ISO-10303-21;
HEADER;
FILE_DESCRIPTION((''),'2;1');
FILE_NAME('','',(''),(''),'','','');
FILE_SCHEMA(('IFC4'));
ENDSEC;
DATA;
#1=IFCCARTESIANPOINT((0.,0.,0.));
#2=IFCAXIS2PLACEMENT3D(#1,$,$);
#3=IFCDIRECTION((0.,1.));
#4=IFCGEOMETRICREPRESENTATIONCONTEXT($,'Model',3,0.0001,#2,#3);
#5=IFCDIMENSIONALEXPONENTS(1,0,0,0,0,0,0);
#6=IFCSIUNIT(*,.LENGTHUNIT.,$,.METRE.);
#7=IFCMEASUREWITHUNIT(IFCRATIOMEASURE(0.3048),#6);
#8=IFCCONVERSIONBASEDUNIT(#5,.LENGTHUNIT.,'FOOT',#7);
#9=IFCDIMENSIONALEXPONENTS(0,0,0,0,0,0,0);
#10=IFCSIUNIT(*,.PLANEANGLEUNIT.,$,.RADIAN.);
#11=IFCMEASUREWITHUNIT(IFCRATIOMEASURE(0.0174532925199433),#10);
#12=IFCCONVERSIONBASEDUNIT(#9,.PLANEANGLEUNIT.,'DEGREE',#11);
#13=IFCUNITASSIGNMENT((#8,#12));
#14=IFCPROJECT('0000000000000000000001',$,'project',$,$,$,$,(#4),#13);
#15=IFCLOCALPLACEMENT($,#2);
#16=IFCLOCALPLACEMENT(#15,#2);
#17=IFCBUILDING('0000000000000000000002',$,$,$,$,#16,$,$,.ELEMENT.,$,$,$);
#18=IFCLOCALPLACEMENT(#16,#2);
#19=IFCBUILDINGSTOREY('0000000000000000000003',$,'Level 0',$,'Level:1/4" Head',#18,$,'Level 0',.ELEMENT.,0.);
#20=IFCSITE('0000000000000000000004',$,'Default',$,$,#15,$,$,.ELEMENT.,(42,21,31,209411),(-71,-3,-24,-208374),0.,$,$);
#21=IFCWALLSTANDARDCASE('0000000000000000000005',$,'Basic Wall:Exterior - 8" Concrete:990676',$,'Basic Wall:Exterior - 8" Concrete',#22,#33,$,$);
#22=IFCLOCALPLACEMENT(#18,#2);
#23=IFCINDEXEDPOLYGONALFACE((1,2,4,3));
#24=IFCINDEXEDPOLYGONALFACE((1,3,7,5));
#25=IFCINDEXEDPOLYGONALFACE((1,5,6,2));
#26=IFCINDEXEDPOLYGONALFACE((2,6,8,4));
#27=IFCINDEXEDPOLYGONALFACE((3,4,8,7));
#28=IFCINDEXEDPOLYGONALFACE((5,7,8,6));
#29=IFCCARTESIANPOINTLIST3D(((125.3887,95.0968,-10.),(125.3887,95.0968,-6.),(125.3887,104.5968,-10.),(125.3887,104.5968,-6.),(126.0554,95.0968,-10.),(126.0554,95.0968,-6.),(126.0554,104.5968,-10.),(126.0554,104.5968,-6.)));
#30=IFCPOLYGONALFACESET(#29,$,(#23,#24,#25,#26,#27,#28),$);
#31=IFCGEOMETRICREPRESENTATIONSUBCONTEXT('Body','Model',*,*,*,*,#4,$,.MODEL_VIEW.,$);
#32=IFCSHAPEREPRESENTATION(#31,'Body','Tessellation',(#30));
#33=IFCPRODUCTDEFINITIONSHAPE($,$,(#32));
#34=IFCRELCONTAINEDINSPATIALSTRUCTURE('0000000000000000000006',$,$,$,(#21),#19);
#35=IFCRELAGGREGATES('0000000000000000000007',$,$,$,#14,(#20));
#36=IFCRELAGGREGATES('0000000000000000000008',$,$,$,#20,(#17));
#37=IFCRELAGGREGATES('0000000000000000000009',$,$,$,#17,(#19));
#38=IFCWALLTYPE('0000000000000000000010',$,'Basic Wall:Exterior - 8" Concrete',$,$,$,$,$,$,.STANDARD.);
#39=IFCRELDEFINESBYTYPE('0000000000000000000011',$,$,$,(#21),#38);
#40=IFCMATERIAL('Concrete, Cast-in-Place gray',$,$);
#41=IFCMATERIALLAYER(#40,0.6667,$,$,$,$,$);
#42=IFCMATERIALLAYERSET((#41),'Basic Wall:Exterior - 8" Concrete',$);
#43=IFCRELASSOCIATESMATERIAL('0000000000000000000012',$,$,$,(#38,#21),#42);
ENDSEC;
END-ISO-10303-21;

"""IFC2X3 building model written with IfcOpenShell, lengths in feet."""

from ifc_helpers import new_model, entity, si_unit, converted_unit, direction, frame, frame_2d, origin, place, context, subcontext, project, spatial, rectangle, extrude, material, layer, layer_set, layer_usage, type_object, element, save


model = new_model("IFC2X3")

# Units and contexts
model_context = context("Model", 3, precision=0.0001, world=origin(), true_north=direction((0.0, 1.0)))
body_context = subcontext(model_context, "Body", "Model", "MODEL_VIEW")
ifc_project = project(units=[converted_unit("LENGTHUNIT", "FOOT", entity("IfcRatioMeasure", 0.3048), si_unit("LENGTHUNIT", "METRE"), dimensions=[1, 0, 0, 0, 0, 0, 0]), converted_unit("PLANEANGLEUNIT", "DEGREE", entity("IfcRatioMeasure", 0.0174532925199433), si_unit("PLANEANGLEUNIT", "RADIAN"), dimensions=[0, 0, 0, 0, 0, 0, 0])], contexts=[model_context])

# Site, building, storey
site_placement = place(None, origin())
site = spatial("IfcSite", under=ifc_project, at=site_placement, Name="Default", CompositionType="ELEMENT", RefLatitude=(42, 21, 31, 209411), RefLongitude=(-71, -3, -24, -208374), RefElevation=0.0)
building_placement = place(site_placement, origin())
building = spatial("IfcBuilding", under=site, at=building_placement, CompositionType="ELEMENT")
storey_placement = place(building_placement, origin())
storey = spatial("IfcBuildingStorey", under=building, at=storey_placement, Name="Level 0", ObjectType="Level:1/4\" Head", LongName="Level 0", CompositionType="ELEMENT", Elevation=0.0)

# Wall
ifc_material_1 = material(Name="Concrete, Cast-in-Place gray")
ifc_layer = layer(ifc_material_1, 0.6667)
ifc_layer_set = layer_set([ifc_layer], Name="Basic Wall:Exterior - 8\" Concrete")
wall_type = type_object("IfcWallType", Name="Basic Wall:Exterior - 8\" Concrete", PredefinedType="STANDARD", material=ifc_layer_set)
ifc_layer_usage_1 = layer_usage(ifc_layer_set, "AXIS2", "NEGATIVE", 0.3333)
wall_1_placement = place(storey_placement, frame((125.722, 95.0968, -10.0), z_axis=(0.0, 0.0, 1.0), x_axis=(0.0, 1.0, 0.0)))
element("IfcWallStandardCase", 1, at=wall_1_placement, inside=storey, type_object=wall_type, material=ifc_layer_usage_1, Name="Basic Wall:Exterior - 8\" Concrete:990676", ObjectType="Basic Wall:Exterior - 8\" Concrete", context=body_context, shape_type="SweptSolid", body=[
    extrude(rectangle(XDim=9.5, YDim=0.6667, at=frame_2d((4.75, 0.0), x_axis=(-1.0, 0.0))), origin(), (0.0, 0.0, 1.0), 4.0),
])

save(model, "model.ifc")
